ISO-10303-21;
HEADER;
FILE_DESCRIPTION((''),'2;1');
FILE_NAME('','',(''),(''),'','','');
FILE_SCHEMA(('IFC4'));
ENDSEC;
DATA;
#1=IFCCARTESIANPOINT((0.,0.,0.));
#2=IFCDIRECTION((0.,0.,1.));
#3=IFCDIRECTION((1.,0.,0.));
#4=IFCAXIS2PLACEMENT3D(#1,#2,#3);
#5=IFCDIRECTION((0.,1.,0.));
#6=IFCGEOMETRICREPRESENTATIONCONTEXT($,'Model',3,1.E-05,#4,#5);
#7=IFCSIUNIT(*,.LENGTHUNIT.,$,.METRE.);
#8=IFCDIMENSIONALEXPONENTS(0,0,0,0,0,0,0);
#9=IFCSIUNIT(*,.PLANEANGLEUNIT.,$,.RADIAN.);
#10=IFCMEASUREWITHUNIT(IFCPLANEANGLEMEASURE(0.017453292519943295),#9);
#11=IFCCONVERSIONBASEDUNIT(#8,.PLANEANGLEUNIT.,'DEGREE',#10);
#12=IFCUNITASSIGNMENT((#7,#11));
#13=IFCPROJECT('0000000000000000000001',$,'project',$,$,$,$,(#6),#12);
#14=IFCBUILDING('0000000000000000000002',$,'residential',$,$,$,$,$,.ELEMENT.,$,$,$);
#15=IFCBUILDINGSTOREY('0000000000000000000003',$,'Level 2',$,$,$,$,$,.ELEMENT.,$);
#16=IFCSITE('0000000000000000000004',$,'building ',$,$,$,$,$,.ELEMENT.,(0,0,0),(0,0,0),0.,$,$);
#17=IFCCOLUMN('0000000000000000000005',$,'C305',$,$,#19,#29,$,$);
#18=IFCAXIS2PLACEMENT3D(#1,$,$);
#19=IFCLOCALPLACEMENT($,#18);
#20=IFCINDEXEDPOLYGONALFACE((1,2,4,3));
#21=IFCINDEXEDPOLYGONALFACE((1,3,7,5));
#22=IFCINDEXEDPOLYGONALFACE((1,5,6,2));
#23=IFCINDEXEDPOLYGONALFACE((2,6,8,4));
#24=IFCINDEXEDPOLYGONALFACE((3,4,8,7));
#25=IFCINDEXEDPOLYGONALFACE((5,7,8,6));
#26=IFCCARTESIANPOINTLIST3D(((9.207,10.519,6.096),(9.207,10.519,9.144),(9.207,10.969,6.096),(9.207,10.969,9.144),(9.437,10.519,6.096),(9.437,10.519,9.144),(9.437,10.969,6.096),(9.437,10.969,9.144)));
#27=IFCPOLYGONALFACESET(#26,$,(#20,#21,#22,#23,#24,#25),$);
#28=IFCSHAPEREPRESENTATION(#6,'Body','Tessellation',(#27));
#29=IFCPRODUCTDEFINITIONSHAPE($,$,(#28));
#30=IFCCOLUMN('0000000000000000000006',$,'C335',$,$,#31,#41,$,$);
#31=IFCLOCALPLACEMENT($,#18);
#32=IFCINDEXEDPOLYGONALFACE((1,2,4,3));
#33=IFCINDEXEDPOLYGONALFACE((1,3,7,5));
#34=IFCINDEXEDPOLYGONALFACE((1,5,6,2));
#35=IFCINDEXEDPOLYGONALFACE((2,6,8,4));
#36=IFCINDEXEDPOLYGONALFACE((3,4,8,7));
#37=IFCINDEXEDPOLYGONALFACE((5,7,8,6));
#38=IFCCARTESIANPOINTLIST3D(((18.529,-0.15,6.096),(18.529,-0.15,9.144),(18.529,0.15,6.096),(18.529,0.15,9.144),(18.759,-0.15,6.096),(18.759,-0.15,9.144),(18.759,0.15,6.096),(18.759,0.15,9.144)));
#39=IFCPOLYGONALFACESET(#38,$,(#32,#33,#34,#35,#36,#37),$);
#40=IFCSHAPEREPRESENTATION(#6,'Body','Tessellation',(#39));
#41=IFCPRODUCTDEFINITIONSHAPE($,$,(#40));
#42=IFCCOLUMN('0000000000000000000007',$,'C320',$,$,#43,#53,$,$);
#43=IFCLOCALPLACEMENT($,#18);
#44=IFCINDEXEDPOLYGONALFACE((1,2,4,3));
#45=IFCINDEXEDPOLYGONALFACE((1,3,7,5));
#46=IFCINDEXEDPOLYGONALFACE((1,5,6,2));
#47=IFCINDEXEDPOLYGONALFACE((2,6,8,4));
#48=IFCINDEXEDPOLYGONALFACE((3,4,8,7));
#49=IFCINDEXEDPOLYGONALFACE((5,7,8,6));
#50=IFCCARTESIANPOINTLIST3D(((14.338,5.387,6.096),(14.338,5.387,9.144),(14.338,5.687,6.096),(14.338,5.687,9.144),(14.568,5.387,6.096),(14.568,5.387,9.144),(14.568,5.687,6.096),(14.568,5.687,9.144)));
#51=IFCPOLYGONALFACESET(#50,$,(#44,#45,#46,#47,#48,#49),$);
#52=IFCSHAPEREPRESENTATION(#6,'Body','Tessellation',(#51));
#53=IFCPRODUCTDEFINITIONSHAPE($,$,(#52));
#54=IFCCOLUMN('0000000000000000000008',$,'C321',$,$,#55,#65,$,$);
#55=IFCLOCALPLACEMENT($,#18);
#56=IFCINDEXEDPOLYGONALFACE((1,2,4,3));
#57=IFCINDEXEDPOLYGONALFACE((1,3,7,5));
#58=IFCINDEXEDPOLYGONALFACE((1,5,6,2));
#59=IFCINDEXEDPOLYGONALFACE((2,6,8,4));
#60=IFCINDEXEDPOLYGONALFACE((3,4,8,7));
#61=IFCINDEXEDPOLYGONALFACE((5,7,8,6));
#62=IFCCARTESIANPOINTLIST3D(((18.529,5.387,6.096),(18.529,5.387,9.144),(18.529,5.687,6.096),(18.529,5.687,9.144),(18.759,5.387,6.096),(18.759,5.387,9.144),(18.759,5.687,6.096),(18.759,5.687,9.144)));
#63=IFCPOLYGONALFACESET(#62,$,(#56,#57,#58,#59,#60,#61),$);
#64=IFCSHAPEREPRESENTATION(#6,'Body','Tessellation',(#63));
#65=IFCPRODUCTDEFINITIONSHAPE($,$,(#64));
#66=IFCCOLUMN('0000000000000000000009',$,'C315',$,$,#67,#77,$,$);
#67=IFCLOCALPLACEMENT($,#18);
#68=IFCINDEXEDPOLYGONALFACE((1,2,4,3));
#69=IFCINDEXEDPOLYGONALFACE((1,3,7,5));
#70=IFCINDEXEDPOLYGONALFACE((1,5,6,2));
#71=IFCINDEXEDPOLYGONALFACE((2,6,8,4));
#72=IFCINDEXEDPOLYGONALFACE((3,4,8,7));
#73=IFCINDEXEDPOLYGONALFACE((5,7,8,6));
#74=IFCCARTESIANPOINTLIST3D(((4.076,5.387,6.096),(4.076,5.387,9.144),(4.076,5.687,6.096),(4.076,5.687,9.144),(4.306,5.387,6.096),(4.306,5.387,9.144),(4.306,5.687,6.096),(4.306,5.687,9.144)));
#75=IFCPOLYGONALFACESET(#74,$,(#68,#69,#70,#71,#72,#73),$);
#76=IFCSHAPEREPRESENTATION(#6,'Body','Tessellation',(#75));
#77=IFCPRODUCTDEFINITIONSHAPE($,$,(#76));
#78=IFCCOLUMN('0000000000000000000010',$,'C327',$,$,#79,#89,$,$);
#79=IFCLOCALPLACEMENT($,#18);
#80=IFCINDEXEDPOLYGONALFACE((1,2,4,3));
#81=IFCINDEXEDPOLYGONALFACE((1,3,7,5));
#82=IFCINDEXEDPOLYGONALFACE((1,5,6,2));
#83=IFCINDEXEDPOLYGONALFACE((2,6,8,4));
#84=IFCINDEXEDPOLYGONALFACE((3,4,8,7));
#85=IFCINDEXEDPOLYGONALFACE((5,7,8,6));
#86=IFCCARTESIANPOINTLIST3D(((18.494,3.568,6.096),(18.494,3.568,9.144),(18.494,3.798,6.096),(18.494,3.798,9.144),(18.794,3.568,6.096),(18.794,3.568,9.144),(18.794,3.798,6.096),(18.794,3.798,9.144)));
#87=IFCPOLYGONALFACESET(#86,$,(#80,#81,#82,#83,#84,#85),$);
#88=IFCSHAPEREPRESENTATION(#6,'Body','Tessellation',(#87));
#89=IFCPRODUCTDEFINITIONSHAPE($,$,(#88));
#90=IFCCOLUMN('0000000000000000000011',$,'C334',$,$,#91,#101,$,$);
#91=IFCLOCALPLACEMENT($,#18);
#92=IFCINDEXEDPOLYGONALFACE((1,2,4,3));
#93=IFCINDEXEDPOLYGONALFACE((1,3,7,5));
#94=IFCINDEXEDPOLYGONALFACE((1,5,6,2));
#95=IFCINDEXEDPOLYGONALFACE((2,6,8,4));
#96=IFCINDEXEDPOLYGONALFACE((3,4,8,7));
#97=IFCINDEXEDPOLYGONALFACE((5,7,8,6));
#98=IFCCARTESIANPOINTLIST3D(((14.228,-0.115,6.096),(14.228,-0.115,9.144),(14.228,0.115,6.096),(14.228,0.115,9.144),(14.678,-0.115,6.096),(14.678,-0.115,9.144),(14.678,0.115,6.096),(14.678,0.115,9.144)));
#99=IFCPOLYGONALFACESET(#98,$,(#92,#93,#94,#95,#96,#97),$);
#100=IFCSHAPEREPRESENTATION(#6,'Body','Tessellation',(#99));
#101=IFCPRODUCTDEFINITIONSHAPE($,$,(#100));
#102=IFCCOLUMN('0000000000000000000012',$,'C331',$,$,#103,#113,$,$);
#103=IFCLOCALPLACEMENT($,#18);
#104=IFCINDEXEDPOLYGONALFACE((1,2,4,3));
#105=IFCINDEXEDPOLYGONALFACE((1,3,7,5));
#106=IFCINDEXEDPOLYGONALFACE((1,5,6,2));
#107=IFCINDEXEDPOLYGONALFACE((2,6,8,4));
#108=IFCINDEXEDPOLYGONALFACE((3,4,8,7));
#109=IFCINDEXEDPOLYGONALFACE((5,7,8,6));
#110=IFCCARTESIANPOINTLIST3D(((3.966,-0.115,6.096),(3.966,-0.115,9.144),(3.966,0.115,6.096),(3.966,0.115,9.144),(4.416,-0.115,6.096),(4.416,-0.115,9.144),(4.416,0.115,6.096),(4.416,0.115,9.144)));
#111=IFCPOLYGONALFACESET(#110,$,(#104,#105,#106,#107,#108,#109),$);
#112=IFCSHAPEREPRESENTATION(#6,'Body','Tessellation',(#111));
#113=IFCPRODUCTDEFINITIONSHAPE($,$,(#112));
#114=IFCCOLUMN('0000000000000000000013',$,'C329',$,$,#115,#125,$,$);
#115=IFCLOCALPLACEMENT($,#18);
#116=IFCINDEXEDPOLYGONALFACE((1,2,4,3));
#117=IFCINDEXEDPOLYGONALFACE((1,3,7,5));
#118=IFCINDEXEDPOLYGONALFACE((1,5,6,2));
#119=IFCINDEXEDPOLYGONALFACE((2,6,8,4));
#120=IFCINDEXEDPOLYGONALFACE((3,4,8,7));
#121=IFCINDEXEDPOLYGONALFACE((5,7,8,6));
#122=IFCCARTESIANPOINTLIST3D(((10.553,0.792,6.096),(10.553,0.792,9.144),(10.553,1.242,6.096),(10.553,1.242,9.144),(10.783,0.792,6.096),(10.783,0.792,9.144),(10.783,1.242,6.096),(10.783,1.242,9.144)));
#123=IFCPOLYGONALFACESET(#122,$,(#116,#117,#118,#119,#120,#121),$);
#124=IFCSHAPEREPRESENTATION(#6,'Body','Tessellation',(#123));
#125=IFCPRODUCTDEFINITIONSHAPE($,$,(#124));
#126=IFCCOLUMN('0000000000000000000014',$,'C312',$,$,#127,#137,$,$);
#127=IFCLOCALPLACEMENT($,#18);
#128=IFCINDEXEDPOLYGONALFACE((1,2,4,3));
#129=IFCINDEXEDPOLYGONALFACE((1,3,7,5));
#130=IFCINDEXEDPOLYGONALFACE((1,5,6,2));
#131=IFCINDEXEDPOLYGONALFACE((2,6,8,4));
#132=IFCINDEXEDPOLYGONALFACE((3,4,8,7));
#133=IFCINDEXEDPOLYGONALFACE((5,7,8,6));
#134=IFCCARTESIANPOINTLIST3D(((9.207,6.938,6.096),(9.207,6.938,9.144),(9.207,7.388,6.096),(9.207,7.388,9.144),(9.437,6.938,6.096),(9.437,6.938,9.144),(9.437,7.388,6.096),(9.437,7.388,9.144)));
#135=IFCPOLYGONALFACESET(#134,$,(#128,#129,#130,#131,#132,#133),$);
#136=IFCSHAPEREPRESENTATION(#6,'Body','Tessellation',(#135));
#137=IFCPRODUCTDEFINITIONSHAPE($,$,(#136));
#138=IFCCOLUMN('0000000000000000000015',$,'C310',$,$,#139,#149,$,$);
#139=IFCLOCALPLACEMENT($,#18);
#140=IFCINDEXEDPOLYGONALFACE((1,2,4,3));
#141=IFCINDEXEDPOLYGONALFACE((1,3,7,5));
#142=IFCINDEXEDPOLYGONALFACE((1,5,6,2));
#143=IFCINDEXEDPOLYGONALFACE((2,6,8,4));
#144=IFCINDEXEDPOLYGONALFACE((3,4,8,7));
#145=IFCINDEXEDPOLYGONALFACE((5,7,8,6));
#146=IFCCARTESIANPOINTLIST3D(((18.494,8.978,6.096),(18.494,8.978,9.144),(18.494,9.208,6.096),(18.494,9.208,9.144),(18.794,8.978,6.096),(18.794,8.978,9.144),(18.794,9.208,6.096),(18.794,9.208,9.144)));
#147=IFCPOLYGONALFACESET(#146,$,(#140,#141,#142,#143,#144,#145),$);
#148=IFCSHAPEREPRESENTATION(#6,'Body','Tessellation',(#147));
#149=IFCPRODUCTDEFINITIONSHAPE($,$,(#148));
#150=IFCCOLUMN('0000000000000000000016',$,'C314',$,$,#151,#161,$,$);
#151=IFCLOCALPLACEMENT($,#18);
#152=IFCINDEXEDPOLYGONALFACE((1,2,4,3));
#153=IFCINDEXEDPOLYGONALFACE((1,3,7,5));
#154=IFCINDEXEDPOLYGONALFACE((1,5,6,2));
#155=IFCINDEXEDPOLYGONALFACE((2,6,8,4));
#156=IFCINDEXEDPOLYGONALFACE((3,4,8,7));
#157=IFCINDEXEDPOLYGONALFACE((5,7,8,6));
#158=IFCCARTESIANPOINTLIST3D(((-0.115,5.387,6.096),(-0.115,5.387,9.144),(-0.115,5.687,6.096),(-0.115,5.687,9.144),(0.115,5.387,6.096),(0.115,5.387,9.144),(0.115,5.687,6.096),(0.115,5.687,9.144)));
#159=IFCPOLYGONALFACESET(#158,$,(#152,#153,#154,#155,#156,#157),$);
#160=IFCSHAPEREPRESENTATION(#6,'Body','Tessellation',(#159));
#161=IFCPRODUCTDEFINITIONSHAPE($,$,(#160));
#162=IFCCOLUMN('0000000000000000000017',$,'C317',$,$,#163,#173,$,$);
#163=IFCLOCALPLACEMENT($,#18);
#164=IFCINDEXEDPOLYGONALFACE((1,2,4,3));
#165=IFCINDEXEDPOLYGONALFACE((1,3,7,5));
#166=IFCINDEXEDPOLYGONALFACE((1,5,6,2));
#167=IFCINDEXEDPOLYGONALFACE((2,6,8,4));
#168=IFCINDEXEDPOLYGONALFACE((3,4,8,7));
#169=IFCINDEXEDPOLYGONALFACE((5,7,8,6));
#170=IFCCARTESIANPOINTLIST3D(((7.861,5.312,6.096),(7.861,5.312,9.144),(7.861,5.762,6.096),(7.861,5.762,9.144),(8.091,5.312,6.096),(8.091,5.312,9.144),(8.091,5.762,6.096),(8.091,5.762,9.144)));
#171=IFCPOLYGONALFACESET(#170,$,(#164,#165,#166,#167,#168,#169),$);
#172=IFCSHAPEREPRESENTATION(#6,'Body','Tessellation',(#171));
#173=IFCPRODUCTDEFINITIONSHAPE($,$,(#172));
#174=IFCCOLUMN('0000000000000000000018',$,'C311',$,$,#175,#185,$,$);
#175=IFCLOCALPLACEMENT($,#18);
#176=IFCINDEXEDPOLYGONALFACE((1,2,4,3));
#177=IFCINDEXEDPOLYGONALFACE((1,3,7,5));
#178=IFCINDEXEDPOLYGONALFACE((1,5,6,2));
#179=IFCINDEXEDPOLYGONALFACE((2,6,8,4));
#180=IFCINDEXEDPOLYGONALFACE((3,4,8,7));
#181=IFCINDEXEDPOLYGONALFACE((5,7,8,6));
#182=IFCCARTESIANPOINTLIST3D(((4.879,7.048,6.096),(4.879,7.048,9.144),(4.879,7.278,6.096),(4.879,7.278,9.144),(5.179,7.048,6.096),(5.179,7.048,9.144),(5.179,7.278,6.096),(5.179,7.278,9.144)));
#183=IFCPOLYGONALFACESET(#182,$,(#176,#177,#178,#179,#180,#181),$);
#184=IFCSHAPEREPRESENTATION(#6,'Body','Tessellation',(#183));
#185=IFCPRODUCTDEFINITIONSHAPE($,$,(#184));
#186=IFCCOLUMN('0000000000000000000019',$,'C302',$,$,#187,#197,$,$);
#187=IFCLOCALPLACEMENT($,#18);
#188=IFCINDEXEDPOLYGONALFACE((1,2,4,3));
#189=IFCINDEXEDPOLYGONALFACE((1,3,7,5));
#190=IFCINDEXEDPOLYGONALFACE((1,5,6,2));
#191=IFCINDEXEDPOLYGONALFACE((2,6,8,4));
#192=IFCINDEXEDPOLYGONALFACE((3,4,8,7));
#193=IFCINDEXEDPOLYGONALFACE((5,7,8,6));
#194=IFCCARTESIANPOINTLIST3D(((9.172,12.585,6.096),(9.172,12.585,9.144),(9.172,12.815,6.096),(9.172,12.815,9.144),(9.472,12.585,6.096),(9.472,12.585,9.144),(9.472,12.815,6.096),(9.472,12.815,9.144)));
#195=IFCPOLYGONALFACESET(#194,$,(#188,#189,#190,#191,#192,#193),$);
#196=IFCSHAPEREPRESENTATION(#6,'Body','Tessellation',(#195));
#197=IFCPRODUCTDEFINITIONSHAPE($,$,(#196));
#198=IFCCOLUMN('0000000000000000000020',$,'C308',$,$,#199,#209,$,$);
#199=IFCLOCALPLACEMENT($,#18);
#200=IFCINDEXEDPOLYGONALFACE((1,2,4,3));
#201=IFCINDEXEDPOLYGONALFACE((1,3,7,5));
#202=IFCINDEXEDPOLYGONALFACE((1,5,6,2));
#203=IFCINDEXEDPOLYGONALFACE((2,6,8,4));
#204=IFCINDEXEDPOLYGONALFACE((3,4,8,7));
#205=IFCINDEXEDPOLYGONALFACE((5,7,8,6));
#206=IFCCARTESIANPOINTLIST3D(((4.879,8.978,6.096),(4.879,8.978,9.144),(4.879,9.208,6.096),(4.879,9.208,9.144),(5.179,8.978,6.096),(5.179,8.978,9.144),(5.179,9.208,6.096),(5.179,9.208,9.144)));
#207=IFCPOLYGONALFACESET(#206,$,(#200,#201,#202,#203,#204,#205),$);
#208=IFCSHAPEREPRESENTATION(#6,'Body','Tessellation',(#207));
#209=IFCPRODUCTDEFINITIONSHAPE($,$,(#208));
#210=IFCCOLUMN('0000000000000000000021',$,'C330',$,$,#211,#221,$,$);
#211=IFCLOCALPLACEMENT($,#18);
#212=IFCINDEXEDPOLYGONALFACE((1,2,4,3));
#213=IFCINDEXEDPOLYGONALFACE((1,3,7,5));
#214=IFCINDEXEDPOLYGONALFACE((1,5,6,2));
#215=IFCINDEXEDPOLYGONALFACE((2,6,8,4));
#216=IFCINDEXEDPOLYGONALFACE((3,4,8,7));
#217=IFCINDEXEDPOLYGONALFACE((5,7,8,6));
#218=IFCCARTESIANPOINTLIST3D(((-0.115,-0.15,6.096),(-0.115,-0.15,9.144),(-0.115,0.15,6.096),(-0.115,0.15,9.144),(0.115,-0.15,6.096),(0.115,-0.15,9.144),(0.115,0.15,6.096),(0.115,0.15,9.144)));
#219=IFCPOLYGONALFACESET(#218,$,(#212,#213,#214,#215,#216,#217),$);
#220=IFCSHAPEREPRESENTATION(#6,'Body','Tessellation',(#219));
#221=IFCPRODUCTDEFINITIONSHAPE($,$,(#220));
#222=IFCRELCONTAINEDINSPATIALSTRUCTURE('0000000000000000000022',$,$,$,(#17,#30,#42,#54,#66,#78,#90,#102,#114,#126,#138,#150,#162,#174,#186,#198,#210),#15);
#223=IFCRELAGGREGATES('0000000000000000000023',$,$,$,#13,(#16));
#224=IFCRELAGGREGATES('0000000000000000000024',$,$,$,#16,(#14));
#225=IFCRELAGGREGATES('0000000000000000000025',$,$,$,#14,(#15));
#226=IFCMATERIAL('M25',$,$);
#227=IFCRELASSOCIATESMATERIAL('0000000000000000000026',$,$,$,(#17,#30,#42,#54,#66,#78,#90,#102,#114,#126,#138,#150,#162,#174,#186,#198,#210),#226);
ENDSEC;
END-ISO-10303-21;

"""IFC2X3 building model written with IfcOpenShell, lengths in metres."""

from ifc_helpers import new_model, entity, si_unit, converted_unit, direction, frame, frame_2d, origin_with_axes, place, context, project, spatial, rectangle, extrude, material, element, save


model = new_model("IFC2X3")

# Units and contexts
model_context = context("Model", 3, precision=1e-05, world=origin_with_axes(), true_north=direction((0.0, 1.0, 0.0)))
ifc_project = project(units=[si_unit("LENGTHUNIT", "METRE"), converted_unit("PLANEANGLEUNIT", "DEGREE", entity("IfcPlaneAngleMeasure", 0.017453292519943295), si_unit("PLANEANGLEUNIT", "RADIAN"), dimensions=[0, 0, 0, 0, 0, 0, 0])], contexts=[model_context])

# Site, building, storey
site = spatial("IfcSite", under=ifc_project, Name="building ", CompositionType="ELEMENT", RefLatitude=(0, 0, 0), RefLongitude=(0, 0, 0), RefElevation=0.0)
building = spatial("IfcBuilding", under=site, Name="residential", CompositionType="ELEMENT")
storey = spatial("IfcBuildingStorey", under=building, Name="Level 2", CompositionType="ELEMENT")

# Columns
ifc_material = material(Name="M25")
placement = place(None, origin_with_axes())
element("IfcColumn", 1, at=placement, inside=storey, material=ifc_material, Name="C305", context=model_context, shape_type="SweptSolid", body=[
    extrude(rectangle(XDim=0.23, YDim=0.45, at=frame_2d((0.0, 0.0), x_axis=(1.0, 0.0, 0.0))), frame((9.322, 10.744, 6.096), z_axis=(0.0, 0.0, 1.0), x_axis=(1.0, 0.0, 0.0)), (0.0, 0.0, 1.0), 3.048),
])
element("IfcColumn", 2, at=placement, inside=storey, material=ifc_material, Name="C335", context=model_context, shape_type="SweptSolid", body=[
    extrude(rectangle(XDim=0.23, YDim=0.3, at=frame_2d((0.0, 0.0), x_axis=(1.0, 0.0, 0.0))), frame((18.644, 0.0, 6.096), z_axis=(0.0, 0.0, 1.0), x_axis=(1.0, 0.0, 0.0)), (0.0, 0.0, 1.0), 3.048),
])
element("IfcColumn", 3, at=placement, inside=storey, material=ifc_material, Name="C320", context=model_context, shape_type="SweptSolid", body=[
    extrude(rectangle(XDim=0.23, YDim=0.3, at=frame_2d((0.0, 0.0), x_axis=(1.0, 0.0, 0.0))), frame((14.453, 5.537, 6.096), z_axis=(0.0, 0.0, 1.0), x_axis=(1.0, 0.0, 0.0)), (0.0, 0.0, 1.0), 3.048),
])
element("IfcColumn", 4, at=placement, inside=storey, material=ifc_material, Name="C321", context=model_context, shape_type="SweptSolid", body=[
    extrude(rectangle(XDim=0.23, YDim=0.3, at=frame_2d((0.0, 0.0), x_axis=(1.0, 0.0, 0.0))), frame((18.644, 5.537, 6.096), z_axis=(0.0, 0.0, 1.0), x_axis=(1.0, 0.0, 0.0)), (0.0, 0.0, 1.0), 3.048),
])
element("IfcColumn", 5, at=placement, inside=storey, material=ifc_material, Name="C315", context=model_context, shape_type="SweptSolid", body=[
    extrude(rectangle(XDim=0.23, YDim=0.3, at=frame_2d((0.0, 0.0), x_axis=(1.0, 0.0, 0.0))), frame((4.191, 5.537, 6.096), z_axis=(0.0, 0.0, 1.0), x_axis=(1.0, 0.0, 0.0)), (0.0, 0.0, 1.0), 3.048),
])
element("IfcColumn", 6, at=placement, inside=storey, material=ifc_material, Name="C327", context=model_context, shape_type="SweptSolid", body=[
    extrude(rectangle(XDim=0.3, YDim=0.23, at=frame_2d((0.0, 0.0), x_axis=(1.0, 0.0, 0.0))), frame((18.644, 3.683, 6.096), z_axis=(0.0, 0.0, 1.0), x_axis=(1.0, 0.0, 0.0)), (0.0, 0.0, 1.0), 3.048),
])
element("IfcColumn", 7, at=placement, inside=storey, material=ifc_material, Name="C334", context=model_context, shape_type="SweptSolid", body=[
    extrude(rectangle(XDim=0.45, YDim=0.23, at=frame_2d((0.0, 0.0), x_axis=(1.0, 0.0, 0.0))), frame((14.453, 0.0, 6.096), z_axis=(0.0, 0.0, 1.0), x_axis=(1.0, 0.0, 0.0)), (0.0, 0.0, 1.0), 3.048),
])
element("IfcColumn", 8, at=placement, inside=storey, material=ifc_material, Name="C331", context=model_context, shape_type="SweptSolid", body=[
    extrude(rectangle(XDim=0.45, YDim=0.23, at=frame_2d((0.0, 0.0), x_axis=(1.0, 0.0, 0.0))), frame((4.191, 0.0, 6.096), z_axis=(0.0, 0.0, 1.0), x_axis=(1.0, 0.0, 0.0)), (0.0, 0.0, 1.0), 3.048),
])
element("IfcColumn", 9, at=placement, inside=storey, material=ifc_material, Name="C329", context=model_context, shape_type="SweptSolid", body=[
    extrude(rectangle(XDim=0.23, YDim=0.45, at=frame_2d((0.0, 0.0), x_axis=(1.0, 0.0, 0.0))), frame((10.668, 1.017, 6.096), z_axis=(0.0, 0.0, 1.0), x_axis=(1.0, 0.0, 0.0)), (0.0, 0.0, 1.0), 3.048),
])
element("IfcColumn", 10, at=placement, inside=storey, material=ifc_material, Name="C312", context=model_context, shape_type="SweptSolid", body=[
    extrude(rectangle(XDim=0.23, YDim=0.45, at=frame_2d((0.0, 0.0), x_axis=(1.0, 0.0, 0.0))), frame((9.322, 7.163, 6.096), z_axis=(0.0, 0.0, 1.0), x_axis=(1.0, 0.0, 0.0)), (0.0, 0.0, 1.0), 3.048),
])
element("IfcColumn", 11, at=placement, inside=storey, material=ifc_material, Name="C310", context=model_context, shape_type="SweptSolid", body=[
    extrude(rectangle(XDim=0.3, YDim=0.23, at=frame_2d((0.0, 0.0), x_axis=(1.0, 0.0, 0.0))), frame((18.644, 9.093, 6.096), z_axis=(0.0, 0.0, 1.0), x_axis=(1.0, 0.0, 0.0)), (0.0, 0.0, 1.0), 3.048),
])
element("IfcColumn", 12, at=placement, inside=storey, material=ifc_material, Name="C314", context=model_context, shape_type="SweptSolid", body=[
    extrude(rectangle(XDim=0.23, YDim=0.3, at=frame_2d((0.0, 0.0), x_axis=(1.0, 0.0, 0.0))), frame((0.0, 5.537, 6.096), z_axis=(0.0, 0.0, 1.0), x_axis=(1.0, 0.0, 0.0)), (0.0, 0.0, 1.0), 3.048),
])
element("IfcColumn", 13, at=placement, inside=storey, material=ifc_material, Name="C317", context=model_context, shape_type="SweptSolid", body=[
    extrude(rectangle(XDim=0.23, YDim=0.45, at=frame_2d((0.0, 0.0), x_axis=(1.0, 0.0, 0.0))), frame((7.976, 5.537, 6.096), z_axis=(0.0, 0.0, 1.0), x_axis=(1.0, 0.0, 0.0)), (0.0, 0.0, 1.0), 3.048),
])
element("IfcColumn", 14, at=placement, inside=storey, material=ifc_material, Name="C311", context=model_context, shape_type="SweptSolid", body=[
    extrude(rectangle(XDim=0.3, YDim=0.23, at=frame_2d((0.0, 0.0), x_axis=(1.0, 0.0, 0.0))), frame((5.029, 7.163, 6.096), z_axis=(0.0, 0.0, 1.0), x_axis=(1.0, 0.0, 0.0)), (0.0, 0.0, 1.0), 3.048),
])
element("IfcColumn", 15, at=placement, inside=storey, material=ifc_material, Name="C302", context=model_context, shape_type="SweptSolid", body=[
    extrude(rectangle(XDim=0.3, YDim=0.23, at=frame_2d((0.0, 0.0), x_axis=(1.0, 0.0, 0.0))), frame((9.322, 12.7, 6.096), z_axis=(0.0, 0.0, 1.0), x_axis=(1.0, 0.0, 0.0)), (0.0, 0.0, 1.0), 3.048),
])
element("IfcColumn", 16, at=placement, inside=storey, material=ifc_material, Name="C308", context=model_context, shape_type="SweptSolid", body=[
    extrude(rectangle(XDim=0.3, YDim=0.23, at=frame_2d((0.0, 0.0), x_axis=(1.0, 0.0, 0.0))), frame((5.029, 9.093, 6.096), z_axis=(0.0, 0.0, 1.0), x_axis=(1.0, 0.0, 0.0)), (0.0, 0.0, 1.0), 3.048),
])
element("IfcColumn", 17, at=placement, inside=storey, material=ifc_material, Name="C330", context=model_context, shape_type="SweptSolid", body=[
    extrude(rectangle(XDim=0.23, YDim=0.3, at=frame_2d((0.0, 0.0), x_axis=(1.0, 0.0, 0.0))), frame((0.0, 0.0, 6.096), z_axis=(0.0, 0.0, 1.0), x_axis=(1.0, 0.0, 0.0)), (0.0, 0.0, 1.0), 3.048),
])

save(model, "model.ifc")
